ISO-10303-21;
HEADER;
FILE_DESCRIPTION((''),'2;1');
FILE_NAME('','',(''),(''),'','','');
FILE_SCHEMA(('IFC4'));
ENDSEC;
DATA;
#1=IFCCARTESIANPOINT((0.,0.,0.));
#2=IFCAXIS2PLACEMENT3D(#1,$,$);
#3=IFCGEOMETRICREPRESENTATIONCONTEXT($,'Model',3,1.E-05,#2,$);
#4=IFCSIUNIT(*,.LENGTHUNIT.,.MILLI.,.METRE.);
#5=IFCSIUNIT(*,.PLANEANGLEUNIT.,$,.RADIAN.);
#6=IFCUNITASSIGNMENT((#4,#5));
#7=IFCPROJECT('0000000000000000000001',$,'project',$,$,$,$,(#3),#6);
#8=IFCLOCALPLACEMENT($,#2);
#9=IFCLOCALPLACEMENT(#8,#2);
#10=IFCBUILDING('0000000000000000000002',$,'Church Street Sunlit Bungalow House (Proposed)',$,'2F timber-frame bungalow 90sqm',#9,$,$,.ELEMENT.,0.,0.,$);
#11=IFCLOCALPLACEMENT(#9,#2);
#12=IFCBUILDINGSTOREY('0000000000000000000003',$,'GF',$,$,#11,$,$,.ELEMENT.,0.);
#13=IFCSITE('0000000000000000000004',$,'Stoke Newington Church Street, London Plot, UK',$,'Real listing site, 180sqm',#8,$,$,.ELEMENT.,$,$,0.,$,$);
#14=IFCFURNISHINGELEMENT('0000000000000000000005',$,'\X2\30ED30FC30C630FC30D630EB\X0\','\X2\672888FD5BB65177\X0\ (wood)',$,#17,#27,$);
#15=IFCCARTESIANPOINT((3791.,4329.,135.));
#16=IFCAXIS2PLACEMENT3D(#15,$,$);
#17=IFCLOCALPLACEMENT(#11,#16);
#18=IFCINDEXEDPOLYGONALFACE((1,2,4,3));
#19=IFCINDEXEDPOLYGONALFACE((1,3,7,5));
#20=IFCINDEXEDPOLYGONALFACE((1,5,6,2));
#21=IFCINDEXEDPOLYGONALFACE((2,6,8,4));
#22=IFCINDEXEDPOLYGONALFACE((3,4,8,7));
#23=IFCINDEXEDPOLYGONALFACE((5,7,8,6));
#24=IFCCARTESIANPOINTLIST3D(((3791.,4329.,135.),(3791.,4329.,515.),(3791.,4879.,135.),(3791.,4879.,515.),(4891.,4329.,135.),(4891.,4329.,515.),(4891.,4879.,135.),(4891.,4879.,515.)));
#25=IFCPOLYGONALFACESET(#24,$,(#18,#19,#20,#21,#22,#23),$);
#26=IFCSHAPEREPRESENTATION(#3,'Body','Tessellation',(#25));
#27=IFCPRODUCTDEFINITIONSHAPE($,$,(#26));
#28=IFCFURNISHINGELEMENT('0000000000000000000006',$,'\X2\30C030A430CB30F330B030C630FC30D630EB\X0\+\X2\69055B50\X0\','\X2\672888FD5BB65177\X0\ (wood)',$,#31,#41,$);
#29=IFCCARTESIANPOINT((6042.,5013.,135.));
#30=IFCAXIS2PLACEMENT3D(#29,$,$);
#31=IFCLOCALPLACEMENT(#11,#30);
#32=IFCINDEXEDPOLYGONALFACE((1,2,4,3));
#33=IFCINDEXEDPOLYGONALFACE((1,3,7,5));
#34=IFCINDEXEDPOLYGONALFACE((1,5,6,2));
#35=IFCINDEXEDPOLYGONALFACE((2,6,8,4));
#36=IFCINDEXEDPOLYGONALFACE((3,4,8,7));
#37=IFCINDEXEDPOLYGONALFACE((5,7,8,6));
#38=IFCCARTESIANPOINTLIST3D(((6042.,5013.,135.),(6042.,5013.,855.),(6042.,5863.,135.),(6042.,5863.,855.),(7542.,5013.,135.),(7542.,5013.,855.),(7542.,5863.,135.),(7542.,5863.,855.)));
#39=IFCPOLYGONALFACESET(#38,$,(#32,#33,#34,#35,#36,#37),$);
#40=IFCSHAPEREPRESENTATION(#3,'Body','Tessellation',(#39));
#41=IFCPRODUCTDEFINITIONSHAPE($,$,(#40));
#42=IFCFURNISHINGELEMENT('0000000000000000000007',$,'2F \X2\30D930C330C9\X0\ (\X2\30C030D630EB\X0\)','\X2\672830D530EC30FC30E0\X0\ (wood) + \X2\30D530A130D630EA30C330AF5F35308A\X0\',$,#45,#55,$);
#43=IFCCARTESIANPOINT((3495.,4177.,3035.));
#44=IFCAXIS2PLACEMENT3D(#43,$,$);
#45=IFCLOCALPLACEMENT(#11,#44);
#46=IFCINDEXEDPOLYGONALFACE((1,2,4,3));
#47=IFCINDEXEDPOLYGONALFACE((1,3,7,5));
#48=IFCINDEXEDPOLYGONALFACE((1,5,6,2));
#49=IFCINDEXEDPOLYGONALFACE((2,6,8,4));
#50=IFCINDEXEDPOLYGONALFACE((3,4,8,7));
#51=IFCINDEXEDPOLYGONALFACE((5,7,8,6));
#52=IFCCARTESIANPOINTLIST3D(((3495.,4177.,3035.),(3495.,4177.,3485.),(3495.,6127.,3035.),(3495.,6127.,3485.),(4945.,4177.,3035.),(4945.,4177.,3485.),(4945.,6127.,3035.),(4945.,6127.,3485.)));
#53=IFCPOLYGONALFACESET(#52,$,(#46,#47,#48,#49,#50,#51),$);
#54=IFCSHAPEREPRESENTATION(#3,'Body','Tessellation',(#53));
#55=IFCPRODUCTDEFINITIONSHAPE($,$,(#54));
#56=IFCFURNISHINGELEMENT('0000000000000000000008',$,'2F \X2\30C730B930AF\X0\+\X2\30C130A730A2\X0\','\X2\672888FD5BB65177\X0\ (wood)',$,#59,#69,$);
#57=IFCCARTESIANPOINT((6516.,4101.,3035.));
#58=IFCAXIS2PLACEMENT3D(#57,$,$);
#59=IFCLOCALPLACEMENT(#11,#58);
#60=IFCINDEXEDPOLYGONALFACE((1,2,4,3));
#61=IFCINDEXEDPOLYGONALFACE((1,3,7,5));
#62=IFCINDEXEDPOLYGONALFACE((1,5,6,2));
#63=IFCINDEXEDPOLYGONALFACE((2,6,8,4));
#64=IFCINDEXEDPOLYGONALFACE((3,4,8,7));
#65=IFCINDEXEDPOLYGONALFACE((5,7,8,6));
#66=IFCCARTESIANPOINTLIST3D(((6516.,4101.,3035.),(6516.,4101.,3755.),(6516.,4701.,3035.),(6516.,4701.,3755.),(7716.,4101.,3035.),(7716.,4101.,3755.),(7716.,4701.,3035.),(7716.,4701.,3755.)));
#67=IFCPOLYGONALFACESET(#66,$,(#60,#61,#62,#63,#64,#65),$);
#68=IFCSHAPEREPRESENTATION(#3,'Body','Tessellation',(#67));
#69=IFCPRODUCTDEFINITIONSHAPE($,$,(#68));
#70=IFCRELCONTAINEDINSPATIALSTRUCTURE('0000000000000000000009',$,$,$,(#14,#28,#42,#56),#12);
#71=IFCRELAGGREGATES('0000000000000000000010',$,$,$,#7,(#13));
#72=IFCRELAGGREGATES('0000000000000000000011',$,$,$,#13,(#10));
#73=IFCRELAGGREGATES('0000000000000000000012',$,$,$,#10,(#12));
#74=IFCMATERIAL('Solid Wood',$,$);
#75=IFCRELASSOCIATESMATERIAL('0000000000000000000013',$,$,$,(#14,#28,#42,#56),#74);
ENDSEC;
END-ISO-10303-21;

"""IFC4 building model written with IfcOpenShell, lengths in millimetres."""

from ifc_helpers import new_model, si_unit, frame, frame_2d, origin, place, context, project, spatial, rectangle, extrude, material, element, save


model = new_model("IFC4")

# Units and contexts
model_context = context("Model", 3, precision=1e-05, world=origin())
ifc_project = project(units=[si_unit("LENGTHUNIT", "METRE", prefix="MILLI"), si_unit("PLANEANGLEUNIT", "RADIAN")], contexts=[model_context])

# Site, building, storey
site_placement = place(None, origin())
site = spatial("IfcSite", under=ifc_project, at=site_placement, Name="Stoke Newington Church Street, London Plot, UK", ObjectType="Real listing site, 180sqm", CompositionType="ELEMENT", RefElevation=0.0)
building_placement = place(site_placement, origin())
building = spatial("IfcBuilding", under=site, at=building_placement, Name="Church Street Sunlit Bungalow House (Proposed)", ObjectType="2F timber-frame bungalow 90sqm", CompositionType="ELEMENT", ElevationOfRefHeight=0.0, ElevationOfTerrain=0.0)
storey_placement = place(building_placement, origin())
storey = spatial("IfcBuildingStorey", under=building, at=storey_placement, Name="GF", CompositionType="ELEMENT", Elevation=0.0)

# Shared definitions
ifc_material_1 = material(Name="Solid Wood")

# Furnishing elements
furnishing_1_placement = place(storey_placement, frame((3791.0, 4329.0, 135.0)))
element("IfcFurnishingElement", 1, at=furnishing_1_placement, inside=storey, material=ifc_material_1, Name="ローテーブル", Description="木製家具 (wood)", context=model_context, shape_type="SweptSolid", body=[
    extrude(rectangle(XDim=1100.0, YDim=550.0, at=frame_2d((550.0, 275.0))), frame((3791.0, 4329.0, 135.0)), (0.0, 0.0, 1.0), 380.0),
])
furnishing_2_placement = place(storey_placement, frame((6042.0, 5013.0, 135.0)))
element("IfcFurnishingElement", 2, at=furnishing_2_placement, inside=storey, material=ifc_material_1, Name="ダイニングテーブル+椅子", Description="木製家具 (wood)", context=model_context, shape_type="SweptSolid", body=[
    extrude(rectangle(XDim=1500.0, YDim=850.0, at=frame_2d((750.0, 425.0))), frame((6042.0, 5013.0, 135.0)), (0.0, 0.0, 1.0), 720.0),
])
furnishing_3_placement = place(storey_placement, frame((3495.0, 4177.0, 3035.0)))
element("IfcFurnishingElement", 3, at=furnishing_3_placement, inside=storey, material=ifc_material_1, Name="2F ベッド (ダブル)", Description="木フレーム (wood) + ファブリック張り", context=model_context, shape_type="SweptSolid", body=[
    extrude(rectangle(XDim=1450.0, YDim=1950.0, at=frame_2d((725.0, 975.0))), frame((3495.0, 4177.0, 3035.0)), (0.0, 0.0, 1.0), 450.0),
])
furnishing_4_placement = place(storey_placement, frame((6516.0, 4101.0, 3035.0)))
element("IfcFurnishingElement", 4, at=furnishing_4_placement, inside=storey, material=ifc_material_1, Name="2F デスク+チェア", Description="木製家具 (wood)", context=model_context, shape_type="SweptSolid", body=[
    extrude(rectangle(XDim=1200.0, YDim=600.0, at=frame_2d((600.0, 300.0))), frame((6516.0, 4101.0, 3035.0)), (0.0, 0.0, 1.0), 720.0),
])

save(model, "model.ifc")
